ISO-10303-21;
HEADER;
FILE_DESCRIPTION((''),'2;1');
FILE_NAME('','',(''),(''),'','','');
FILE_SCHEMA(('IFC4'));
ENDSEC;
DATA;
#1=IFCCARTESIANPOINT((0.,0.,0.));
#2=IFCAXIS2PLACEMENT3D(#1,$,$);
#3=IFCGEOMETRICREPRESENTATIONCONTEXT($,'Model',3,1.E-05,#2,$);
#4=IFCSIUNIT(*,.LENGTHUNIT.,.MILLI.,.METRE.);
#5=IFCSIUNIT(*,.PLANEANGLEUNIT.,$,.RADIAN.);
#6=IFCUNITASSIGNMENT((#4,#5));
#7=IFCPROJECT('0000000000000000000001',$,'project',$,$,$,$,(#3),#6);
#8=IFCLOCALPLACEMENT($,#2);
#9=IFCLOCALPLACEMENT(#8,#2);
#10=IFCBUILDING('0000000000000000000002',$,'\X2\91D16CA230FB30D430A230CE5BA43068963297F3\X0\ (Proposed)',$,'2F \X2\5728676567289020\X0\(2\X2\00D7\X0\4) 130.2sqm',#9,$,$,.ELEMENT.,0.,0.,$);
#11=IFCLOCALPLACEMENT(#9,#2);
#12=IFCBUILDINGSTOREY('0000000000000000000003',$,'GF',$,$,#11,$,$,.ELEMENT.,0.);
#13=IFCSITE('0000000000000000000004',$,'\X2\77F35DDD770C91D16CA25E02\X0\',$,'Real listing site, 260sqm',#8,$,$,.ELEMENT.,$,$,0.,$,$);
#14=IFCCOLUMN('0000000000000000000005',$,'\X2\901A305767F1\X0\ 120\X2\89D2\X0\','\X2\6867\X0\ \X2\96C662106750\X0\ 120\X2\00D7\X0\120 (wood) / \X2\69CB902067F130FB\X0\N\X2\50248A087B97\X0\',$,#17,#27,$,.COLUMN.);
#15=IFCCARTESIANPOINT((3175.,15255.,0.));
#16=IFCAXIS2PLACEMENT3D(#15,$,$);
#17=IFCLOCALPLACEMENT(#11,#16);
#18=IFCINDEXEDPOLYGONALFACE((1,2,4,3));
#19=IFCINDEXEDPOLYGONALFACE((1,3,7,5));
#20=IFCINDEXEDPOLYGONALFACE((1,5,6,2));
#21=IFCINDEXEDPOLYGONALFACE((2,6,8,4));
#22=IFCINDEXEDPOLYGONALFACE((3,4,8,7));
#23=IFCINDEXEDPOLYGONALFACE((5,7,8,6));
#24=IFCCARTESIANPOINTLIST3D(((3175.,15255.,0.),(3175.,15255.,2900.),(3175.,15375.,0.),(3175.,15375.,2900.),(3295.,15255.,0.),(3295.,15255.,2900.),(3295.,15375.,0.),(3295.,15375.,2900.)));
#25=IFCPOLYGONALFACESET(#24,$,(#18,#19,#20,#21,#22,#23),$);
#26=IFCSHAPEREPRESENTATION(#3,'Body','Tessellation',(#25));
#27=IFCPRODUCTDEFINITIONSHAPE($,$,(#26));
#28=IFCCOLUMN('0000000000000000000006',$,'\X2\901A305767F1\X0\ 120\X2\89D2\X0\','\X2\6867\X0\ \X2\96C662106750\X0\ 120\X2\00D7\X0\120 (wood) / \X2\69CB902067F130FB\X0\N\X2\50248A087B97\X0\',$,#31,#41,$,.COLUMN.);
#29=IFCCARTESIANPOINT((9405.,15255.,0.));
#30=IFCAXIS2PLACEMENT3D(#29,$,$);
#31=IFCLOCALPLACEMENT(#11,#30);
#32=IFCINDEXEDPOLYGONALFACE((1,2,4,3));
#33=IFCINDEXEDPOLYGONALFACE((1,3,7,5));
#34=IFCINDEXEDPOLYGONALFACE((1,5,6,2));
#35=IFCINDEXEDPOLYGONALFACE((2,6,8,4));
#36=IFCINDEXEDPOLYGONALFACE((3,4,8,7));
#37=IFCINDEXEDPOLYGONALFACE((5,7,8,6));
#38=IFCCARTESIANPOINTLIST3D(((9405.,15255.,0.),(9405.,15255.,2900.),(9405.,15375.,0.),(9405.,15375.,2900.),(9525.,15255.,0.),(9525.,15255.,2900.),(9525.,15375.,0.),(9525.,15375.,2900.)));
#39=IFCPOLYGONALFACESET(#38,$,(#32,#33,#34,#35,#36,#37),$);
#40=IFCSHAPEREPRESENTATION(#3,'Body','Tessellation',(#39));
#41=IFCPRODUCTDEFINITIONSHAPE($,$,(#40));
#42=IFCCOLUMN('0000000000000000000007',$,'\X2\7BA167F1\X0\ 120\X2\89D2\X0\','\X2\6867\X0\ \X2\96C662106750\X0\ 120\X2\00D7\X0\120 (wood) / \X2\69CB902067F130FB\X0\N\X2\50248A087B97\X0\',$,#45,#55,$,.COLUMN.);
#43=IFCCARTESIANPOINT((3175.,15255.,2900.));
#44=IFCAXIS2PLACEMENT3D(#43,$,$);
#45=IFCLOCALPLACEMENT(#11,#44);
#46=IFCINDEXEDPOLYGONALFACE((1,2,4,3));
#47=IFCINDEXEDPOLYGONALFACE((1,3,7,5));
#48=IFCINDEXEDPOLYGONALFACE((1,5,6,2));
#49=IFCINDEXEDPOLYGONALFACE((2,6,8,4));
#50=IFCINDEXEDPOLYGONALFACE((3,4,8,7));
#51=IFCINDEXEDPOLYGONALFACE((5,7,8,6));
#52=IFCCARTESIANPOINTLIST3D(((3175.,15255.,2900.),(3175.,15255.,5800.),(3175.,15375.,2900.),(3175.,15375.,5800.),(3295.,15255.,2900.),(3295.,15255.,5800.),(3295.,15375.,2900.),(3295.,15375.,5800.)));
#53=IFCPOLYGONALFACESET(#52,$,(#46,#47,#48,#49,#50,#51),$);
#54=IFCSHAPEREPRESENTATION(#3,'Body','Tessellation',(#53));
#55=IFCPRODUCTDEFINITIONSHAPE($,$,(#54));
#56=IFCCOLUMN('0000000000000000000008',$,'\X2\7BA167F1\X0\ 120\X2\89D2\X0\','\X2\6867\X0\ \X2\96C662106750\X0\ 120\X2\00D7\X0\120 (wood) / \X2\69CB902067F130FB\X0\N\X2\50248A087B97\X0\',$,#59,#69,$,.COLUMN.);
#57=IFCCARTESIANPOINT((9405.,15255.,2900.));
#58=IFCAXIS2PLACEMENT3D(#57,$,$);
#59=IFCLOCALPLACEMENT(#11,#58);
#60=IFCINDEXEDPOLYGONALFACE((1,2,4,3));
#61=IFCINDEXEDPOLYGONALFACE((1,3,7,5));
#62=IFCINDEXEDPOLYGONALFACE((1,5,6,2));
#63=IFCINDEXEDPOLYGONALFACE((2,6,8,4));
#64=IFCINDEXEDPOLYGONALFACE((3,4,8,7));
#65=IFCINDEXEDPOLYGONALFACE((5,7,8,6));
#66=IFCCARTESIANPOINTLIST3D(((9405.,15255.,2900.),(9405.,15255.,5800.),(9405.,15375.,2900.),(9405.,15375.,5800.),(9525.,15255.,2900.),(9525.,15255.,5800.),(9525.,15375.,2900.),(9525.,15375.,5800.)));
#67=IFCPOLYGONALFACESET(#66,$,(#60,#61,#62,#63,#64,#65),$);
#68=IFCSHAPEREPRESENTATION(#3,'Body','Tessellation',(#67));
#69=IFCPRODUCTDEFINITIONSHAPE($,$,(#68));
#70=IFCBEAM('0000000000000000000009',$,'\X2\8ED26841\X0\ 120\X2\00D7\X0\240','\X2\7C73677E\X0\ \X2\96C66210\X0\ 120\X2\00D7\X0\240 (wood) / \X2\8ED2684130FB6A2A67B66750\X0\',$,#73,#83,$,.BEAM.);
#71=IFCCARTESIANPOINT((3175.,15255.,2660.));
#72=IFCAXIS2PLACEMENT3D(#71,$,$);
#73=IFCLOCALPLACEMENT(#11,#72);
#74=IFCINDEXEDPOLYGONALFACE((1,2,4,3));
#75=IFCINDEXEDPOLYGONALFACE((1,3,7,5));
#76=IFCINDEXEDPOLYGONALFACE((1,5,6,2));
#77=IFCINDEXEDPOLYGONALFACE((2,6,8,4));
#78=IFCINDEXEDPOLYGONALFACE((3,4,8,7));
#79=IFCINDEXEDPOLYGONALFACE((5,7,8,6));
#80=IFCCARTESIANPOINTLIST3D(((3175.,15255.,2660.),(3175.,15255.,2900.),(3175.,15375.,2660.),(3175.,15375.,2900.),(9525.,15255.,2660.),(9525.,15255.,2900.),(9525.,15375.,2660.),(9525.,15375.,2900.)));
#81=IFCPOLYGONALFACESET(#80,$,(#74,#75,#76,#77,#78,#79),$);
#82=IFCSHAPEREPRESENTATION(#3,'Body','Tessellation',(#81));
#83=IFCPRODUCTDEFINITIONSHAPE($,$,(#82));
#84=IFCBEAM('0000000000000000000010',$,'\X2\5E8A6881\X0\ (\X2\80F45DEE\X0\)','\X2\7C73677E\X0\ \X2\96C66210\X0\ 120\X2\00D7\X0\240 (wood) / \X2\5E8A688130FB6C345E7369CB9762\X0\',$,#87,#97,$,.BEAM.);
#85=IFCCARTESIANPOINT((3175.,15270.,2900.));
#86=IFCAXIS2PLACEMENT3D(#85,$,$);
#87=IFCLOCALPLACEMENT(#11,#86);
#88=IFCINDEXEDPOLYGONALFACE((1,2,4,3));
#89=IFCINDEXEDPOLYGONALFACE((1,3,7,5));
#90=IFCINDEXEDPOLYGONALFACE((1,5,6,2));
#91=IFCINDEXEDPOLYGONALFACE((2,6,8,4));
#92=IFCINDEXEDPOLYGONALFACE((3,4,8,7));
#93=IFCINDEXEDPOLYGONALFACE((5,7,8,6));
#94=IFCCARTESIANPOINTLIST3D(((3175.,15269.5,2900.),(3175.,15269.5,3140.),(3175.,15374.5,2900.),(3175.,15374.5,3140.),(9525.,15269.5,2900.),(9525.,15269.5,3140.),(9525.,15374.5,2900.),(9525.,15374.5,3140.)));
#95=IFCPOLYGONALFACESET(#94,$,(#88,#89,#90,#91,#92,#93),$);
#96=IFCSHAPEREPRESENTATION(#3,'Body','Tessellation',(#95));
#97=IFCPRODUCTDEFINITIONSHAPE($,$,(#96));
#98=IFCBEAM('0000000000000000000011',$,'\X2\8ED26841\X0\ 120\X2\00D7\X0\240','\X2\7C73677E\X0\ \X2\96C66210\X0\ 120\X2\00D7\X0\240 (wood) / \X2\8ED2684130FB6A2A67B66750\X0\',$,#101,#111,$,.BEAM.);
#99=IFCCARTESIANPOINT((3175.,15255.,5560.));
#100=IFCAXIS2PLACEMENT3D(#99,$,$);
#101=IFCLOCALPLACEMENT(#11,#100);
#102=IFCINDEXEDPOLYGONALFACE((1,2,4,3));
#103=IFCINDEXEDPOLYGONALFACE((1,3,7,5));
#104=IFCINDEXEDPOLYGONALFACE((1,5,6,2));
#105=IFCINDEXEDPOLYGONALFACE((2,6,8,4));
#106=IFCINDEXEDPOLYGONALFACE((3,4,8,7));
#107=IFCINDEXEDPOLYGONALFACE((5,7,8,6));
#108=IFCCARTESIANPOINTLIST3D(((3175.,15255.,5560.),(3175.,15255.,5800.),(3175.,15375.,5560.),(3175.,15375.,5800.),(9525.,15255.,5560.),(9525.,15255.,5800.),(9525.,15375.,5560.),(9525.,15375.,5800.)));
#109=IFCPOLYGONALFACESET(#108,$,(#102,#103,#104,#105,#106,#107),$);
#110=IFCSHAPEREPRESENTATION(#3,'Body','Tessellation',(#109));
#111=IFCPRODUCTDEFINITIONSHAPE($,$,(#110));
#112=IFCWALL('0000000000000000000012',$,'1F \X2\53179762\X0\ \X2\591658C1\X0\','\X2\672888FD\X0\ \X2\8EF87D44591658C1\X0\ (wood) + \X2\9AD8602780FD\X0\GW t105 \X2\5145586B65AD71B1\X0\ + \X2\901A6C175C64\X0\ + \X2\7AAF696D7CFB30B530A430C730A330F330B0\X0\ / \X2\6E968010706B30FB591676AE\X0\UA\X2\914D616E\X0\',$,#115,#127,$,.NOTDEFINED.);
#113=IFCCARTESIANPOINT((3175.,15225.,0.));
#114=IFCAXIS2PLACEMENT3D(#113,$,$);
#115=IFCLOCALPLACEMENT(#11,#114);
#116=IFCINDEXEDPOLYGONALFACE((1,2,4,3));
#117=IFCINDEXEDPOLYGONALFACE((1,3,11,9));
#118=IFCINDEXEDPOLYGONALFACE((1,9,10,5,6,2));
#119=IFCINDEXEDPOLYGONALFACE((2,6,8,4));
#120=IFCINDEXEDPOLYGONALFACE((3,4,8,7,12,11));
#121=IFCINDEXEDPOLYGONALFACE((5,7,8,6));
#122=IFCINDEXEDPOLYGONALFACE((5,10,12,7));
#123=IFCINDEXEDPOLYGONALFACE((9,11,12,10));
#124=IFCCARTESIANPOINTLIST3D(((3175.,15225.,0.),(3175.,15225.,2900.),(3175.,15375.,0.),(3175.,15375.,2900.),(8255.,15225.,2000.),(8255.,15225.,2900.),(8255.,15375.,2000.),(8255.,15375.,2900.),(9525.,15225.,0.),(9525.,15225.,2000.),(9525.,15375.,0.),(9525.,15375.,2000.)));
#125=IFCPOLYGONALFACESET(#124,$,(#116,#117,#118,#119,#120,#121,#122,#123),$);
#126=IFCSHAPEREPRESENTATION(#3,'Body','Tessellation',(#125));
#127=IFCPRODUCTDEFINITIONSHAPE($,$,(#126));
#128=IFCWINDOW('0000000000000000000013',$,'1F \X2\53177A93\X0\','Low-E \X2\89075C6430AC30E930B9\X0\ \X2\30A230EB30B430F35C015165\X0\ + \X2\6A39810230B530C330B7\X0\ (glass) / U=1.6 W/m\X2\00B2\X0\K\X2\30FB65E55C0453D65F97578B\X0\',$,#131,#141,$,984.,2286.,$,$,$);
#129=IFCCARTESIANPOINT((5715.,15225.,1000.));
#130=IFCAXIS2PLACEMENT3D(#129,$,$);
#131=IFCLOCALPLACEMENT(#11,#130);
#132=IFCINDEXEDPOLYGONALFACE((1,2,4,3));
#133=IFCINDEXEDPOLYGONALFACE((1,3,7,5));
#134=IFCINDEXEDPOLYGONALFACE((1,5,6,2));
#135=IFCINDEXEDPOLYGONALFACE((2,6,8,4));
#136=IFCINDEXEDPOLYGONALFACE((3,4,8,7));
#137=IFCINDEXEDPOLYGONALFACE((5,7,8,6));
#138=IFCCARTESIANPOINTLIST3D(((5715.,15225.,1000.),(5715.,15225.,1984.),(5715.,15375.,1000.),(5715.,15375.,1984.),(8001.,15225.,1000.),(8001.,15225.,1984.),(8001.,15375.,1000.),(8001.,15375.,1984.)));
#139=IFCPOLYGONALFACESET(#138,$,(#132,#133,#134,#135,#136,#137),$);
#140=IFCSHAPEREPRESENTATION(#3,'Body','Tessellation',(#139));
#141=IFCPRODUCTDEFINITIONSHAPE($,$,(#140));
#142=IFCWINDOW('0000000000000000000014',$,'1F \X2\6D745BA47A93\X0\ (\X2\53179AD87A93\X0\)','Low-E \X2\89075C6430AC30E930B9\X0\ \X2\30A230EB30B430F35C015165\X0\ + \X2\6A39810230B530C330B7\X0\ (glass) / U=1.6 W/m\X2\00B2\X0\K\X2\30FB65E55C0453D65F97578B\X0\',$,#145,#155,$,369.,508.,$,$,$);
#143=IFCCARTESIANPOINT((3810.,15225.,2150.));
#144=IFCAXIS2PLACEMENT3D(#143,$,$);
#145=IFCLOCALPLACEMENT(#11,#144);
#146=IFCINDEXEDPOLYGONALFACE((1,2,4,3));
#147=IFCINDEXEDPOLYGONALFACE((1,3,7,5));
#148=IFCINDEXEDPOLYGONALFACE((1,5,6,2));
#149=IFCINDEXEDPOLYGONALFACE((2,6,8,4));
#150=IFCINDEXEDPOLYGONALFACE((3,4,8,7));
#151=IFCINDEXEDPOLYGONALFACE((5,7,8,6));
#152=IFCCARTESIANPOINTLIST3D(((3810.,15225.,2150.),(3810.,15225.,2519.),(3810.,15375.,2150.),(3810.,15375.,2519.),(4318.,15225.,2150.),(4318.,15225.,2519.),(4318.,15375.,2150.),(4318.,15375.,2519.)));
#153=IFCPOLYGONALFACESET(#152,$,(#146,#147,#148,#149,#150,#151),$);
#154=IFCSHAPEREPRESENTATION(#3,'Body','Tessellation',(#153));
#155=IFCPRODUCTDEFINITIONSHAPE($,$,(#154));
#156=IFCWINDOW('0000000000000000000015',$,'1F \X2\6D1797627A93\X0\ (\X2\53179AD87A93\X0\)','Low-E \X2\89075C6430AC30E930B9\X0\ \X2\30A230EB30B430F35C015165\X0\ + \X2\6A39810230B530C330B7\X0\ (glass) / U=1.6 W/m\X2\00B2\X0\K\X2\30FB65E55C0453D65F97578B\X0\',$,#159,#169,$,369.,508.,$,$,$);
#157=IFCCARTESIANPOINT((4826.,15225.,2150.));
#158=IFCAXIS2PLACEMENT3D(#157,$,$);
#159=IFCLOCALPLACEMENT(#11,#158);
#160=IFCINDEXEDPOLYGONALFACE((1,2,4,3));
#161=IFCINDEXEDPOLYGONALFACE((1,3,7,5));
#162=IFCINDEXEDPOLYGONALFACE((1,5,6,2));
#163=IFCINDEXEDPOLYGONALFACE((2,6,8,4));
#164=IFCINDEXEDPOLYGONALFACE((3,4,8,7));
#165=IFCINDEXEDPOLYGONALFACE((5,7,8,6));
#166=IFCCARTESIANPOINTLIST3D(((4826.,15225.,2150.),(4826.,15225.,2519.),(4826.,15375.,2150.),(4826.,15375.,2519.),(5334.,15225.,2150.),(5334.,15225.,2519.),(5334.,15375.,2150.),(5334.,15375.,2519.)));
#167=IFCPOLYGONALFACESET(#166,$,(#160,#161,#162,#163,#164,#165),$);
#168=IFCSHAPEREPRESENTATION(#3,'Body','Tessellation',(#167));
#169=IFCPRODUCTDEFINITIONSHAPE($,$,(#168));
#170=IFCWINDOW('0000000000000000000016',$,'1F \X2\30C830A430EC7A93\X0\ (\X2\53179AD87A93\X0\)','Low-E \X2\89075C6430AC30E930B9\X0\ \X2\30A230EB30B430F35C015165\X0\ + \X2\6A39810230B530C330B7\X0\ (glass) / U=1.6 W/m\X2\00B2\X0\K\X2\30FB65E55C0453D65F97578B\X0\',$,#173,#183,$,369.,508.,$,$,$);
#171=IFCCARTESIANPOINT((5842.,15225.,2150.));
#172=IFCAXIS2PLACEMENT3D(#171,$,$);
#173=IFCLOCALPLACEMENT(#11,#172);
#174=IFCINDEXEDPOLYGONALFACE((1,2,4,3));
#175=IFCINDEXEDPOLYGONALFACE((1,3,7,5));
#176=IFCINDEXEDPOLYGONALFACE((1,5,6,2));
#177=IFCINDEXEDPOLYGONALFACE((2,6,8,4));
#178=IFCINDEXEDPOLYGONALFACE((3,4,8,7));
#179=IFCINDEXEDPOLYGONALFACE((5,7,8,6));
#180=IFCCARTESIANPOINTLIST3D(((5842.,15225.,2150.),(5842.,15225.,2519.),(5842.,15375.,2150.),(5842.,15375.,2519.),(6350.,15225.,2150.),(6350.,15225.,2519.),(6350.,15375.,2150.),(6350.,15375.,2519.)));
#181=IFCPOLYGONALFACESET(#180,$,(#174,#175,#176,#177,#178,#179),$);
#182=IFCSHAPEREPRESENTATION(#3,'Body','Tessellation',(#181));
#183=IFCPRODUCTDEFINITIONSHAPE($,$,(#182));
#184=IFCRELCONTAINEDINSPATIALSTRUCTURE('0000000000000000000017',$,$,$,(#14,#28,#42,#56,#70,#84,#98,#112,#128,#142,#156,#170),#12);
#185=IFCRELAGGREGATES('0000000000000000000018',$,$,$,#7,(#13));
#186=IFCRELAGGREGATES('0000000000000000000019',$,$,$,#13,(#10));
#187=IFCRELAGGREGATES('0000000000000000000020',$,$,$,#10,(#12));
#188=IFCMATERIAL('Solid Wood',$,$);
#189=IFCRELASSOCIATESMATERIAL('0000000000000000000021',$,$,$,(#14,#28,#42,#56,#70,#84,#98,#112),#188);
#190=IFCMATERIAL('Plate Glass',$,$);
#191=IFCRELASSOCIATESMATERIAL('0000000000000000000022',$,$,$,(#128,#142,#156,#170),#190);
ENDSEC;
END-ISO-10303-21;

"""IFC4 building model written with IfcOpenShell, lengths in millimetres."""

from ifc_helpers import new_model, si_unit, frame, frame_2d, origin, place, context, project, spatial, rectangle, extrude, material, element, fill, save


model = new_model("IFC4")

# Units and contexts
model_context = context("Model", 3, precision=1e-05, world=origin())
ifc_project = project(units=[si_unit("LENGTHUNIT", "METRE", prefix="MILLI"), si_unit("PLANEANGLEUNIT", "RADIAN")], contexts=[model_context])

# Site, building, storey
site_placement = place(None, origin())
site = spatial("IfcSite", under=ifc_project, at=site_placement, Name="石川県金沢市", ObjectType="Real listing site, 260sqm", CompositionType="ELEMENT", RefElevation=0.0)
building_placement = place(site_placement, origin())
building = spatial("IfcBuilding", under=site, at=building_placement, Name="金沢・ピアノ室と防音 (Proposed)", ObjectType="2F 在来木造(2×4) 130.2sqm", CompositionType="ELEMENT", ElevationOfRefHeight=0.0, ElevationOfTerrain=0.0)
storey_placement = place(building_placement, origin())
storey = spatial("IfcBuildingStorey", under=building, at=storey_placement, Name="GF", CompositionType="ELEMENT", Elevation=0.0)

# Columns
ifc_material_1 = material(Name="Solid Wood")
column_1_placement = place(storey_placement, frame((3175.0, 15255.0, 0.0)))
element("IfcColumn", 1, at=column_1_placement, inside=storey, material=ifc_material_1, Name="通し柱 120角", Description="桧 集成材 120×120 (wood) / 構造柱・N値計算", PredefinedType="COLUMN", context=model_context, shape_type="SweptSolid", body=[
    extrude(rectangle(XDim=120.0, YDim=120.0, at=frame_2d((60.0, 60.0))), frame((3175.0, 15255.0, 0.0)), (0.0, 0.0, 1.0), 2900.0),
])
column_2_placement = place(storey_placement, frame((9405.0, 15255.0, 0.0)))
element("IfcColumn", 2, at=column_2_placement, inside=storey, material=ifc_material_1, Name="通し柱 120角", Description="桧 集成材 120×120 (wood) / 構造柱・N値計算", PredefinedType="COLUMN", context=model_context, shape_type="SweptSolid", body=[
    extrude(rectangle(XDim=120.0, YDim=120.0, at=frame_2d((60.0, 60.0))), frame((9405.0, 15255.0, 0.0)), (0.0, 0.0, 1.0), 2900.0),
])
column_3_placement = place(storey_placement, frame((3175.0, 15255.0, 2900.0)))
element("IfcColumn", 3, at=column_3_placement, inside=storey, material=ifc_material_1, Name="管柱 120角", Description="桧 集成材 120×120 (wood) / 構造柱・N値計算", PredefinedType="COLUMN", context=model_context, shape_type="SweptSolid", body=[
    extrude(rectangle(XDim=120.0, YDim=120.0, at=frame_2d((60.0, 60.0))), frame((3175.0, 15255.0, 2900.0)), (0.0, 0.0, 1.0), 2900.0),
])
column_4_placement = place(storey_placement, frame((9405.0, 15255.0, 2900.0)))
element("IfcColumn", 4, at=column_4_placement, inside=storey, material=ifc_material_1, Name="管柱 120角", Description="桧 集成材 120×120 (wood) / 構造柱・N値計算", PredefinedType="COLUMN", context=model_context, shape_type="SweptSolid", body=[
    extrude(rectangle(XDim=120.0, YDim=120.0, at=frame_2d((60.0, 60.0))), frame((9405.0, 15255.0, 2900.0)), (0.0, 0.0, 1.0), 2900.0),
])

# Beams
beam_1_placement = place(storey_placement, frame((3175.0, 15255.0, 2660.0)))
element("IfcBeam", 5, at=beam_1_placement, inside=storey, material=ifc_material_1, Name="軒桁 120×240", Description="米松 集成 120×240 (wood) / 軒桁・横架材", PredefinedType="BEAM", context=model_context, shape_type="SweptSolid", body=[
    extrude(rectangle(XDim=6350.0, YDim=120.0, at=frame_2d((3175.0, 60.0))), frame((3175.0, 15255.0, 2660.0)), (0.0, 0.0, 1.0), 240.0),
])
beam_2_placement = place(storey_placement, frame((3175.0, 15270.0, 2900.0)))
element("IfcBeam", 6, at=beam_2_placement, inside=storey, material=ifc_material_1, Name="床梁 (胴差)", Description="米松 集成 120×240 (wood) / 床梁・水平構面", PredefinedType="BEAM", context=model_context, shape_type="SweptSolid", body=[
    extrude(rectangle(XDim=6350.0, YDim=105.0, at=frame_2d((3175.0, 52.0))), frame((3175.0, 15270.0, 2900.0)), (0.0, 0.0, 1.0), 240.0),
])
beam_3_placement = place(storey_placement, frame((3175.0, 15255.0, 5560.0)))
element("IfcBeam", 7, at=beam_3_placement, inside=storey, material=ifc_material_1, Name="軒桁 120×240", Description="米松 集成 120×240 (wood) / 軒桁・横架材", PredefinedType="BEAM", context=model_context, shape_type="SweptSolid", body=[
    extrude(rectangle(XDim=6350.0, YDim=120.0, at=frame_2d((3175.0, 60.0))), frame((3175.0, 15255.0, 5560.0)), (0.0, 0.0, 1.0), 240.0),
])

# Wall, openings, windows
wall_1_placement = place(storey_placement, frame((3175.0, 15225.0, 0.0)))
wall_1 = element("IfcWall", 8, at=wall_1_placement, inside=storey, material=ifc_material_1, Name="1F 北面 外壁", Description="木製 軸組外壁 (wood) + 高性能GW t105 充填断熱 + 通気層 + 窯業系サイディング / 準耐火・外皮UA配慮", PredefinedType="NOTDEFINED", context=model_context, shape_type="SweptSolid", body=[
    extrude(rectangle(XDim=6350.0, YDim=150.0, at=frame_2d((3175.0, 75.0))), frame((3175.0, 15225.0, 0.0)), (0.0, 0.0, 1.0), 2900.0),
])
opening_1_placement = place(storey_placement, frame((5715.0, 15225.0, 1000.0)))
opening_1 = element("IfcOpeningElement", 9, at=opening_1_placement, cuts=wall_1, PredefinedType="NOTDEFINED", context=model_context, shape_type="SweptSolid", body=[
    extrude(rectangle(XDim=2286.0, YDim=150.0, at=frame_2d((1143.0, 75.0))), frame((5715.0, 15225.0, 1000.0)), (0.0, 0.0, 1.0), 984.0),
])
opening_2_placement = place(storey_placement, frame((3810.0, 15225.0, 2150.0)))
opening_2 = element("IfcOpeningElement", 10, at=opening_2_placement, cuts=wall_1, PredefinedType="NOTDEFINED", context=model_context, shape_type="SweptSolid", body=[
    extrude(rectangle(XDim=508.0, YDim=150.0, at=frame_2d((254.0, 75.0))), frame((3810.0, 15225.0, 2150.0)), (0.0, 0.0, 1.0), 369.0),
])
opening_3_placement = place(storey_placement, frame((4826.0, 15225.0, 2150.0)))
opening_3 = element("IfcOpeningElement", 11, at=opening_3_placement, cuts=wall_1, PredefinedType="NOTDEFINED", context=model_context, shape_type="SweptSolid", body=[
    extrude(rectangle(XDim=508.0, YDim=150.0, at=frame_2d((254.0, 75.0))), frame((4826.0, 15225.0, 2150.0)), (0.0, 0.0, 1.0), 369.0),
])
opening_4_placement = place(storey_placement, frame((5842.0, 15225.0, 2150.0)))
opening_4 = element("IfcOpeningElement", 12, at=opening_4_placement, cuts=wall_1, PredefinedType="NOTDEFINED", context=model_context, shape_type="SweptSolid", body=[
    extrude(rectangle(XDim=508.0, YDim=150.0, at=frame_2d((254.0, 75.0))), frame((5842.0, 15225.0, 2150.0)), (0.0, 0.0, 1.0), 369.0),
])
ifc_material_2 = material(Name="Plate Glass")
window_1_placement = place(storey_placement, frame((5715.0, 15225.0, 1000.0)))
window_1 = element("IfcWindow", 13, at=window_1_placement, inside=storey, material=ifc_material_2, Name="1F 北窓", Description="Low-E 複層ガラス アルゴン封入 + 樹脂サッシ (glass) / U=1.6 W/m²K・日射取得型", OverallHeight=984.0, OverallWidth=2286.0, context=model_context, shape_type="SweptSolid", body=[
    extrude(rectangle(XDim=2286.0, YDim=150.0, at=frame_2d((1143.0, 75.0))), frame((5715.0, 15225.0, 1000.0)), (0.0, 0.0, 1.0), 984.0),
])
fill(opening_1, window_1)
window_2_placement = place(storey_placement, frame((3810.0, 15225.0, 2150.0)))
window_2 = element("IfcWindow", 14, at=window_2_placement, inside=storey, material=ifc_material_2, Name="1F 浴室窓 (北高窓)", Description="Low-E 複層ガラス アルゴン封入 + 樹脂サッシ (glass) / U=1.6 W/m²K・日射取得型", OverallHeight=369.0, OverallWidth=508.0, context=model_context, shape_type="SweptSolid", body=[
    extrude(rectangle(XDim=508.0, YDim=150.0, at=frame_2d((254.0, 75.0))), frame((3810.0, 15225.0, 2150.0)), (0.0, 0.0, 1.0), 369.0),
])
fill(opening_2, window_2)
window_3_placement = place(storey_placement, frame((4826.0, 15225.0, 2150.0)))
window_3 = element("IfcWindow", 15, at=window_3_placement, inside=storey, material=ifc_material_2, Name="1F 洗面窓 (北高窓)", Description="Low-E 複層ガラス アルゴン封入 + 樹脂サッシ (glass) / U=1.6 W/m²K・日射取得型", OverallHeight=369.0, OverallWidth=508.0, context=model_context, shape_type="SweptSolid", body=[
    extrude(rectangle(XDim=508.0, YDim=150.0, at=frame_2d((254.0, 75.0))), frame((4826.0, 15225.0, 2150.0)), (0.0, 0.0, 1.0), 369.0),
])
fill(opening_3, window_3)
window_4_placement = place(storey_placement, frame((5842.0, 15225.0, 2150.0)))
window_4 = element("IfcWindow", 16, at=window_4_placement, inside=storey, material=ifc_material_2, Name="1F トイレ窓 (北高窓)", Description="Low-E 複層ガラス アルゴン封入 + 樹脂サッシ (glass) / U=1.6 W/m²K・日射取得型", OverallHeight=369.0, OverallWidth=508.0, context=model_context, shape_type="SweptSolid", body=[
    extrude(rectangle(XDim=508.0, YDim=150.0, at=frame_2d((254.0, 75.0))), frame((5842.0, 15225.0, 2150.0)), (0.0, 0.0, 1.0), 369.0),
])
fill(opening_4, window_4)

save(model, "model.ifc")
